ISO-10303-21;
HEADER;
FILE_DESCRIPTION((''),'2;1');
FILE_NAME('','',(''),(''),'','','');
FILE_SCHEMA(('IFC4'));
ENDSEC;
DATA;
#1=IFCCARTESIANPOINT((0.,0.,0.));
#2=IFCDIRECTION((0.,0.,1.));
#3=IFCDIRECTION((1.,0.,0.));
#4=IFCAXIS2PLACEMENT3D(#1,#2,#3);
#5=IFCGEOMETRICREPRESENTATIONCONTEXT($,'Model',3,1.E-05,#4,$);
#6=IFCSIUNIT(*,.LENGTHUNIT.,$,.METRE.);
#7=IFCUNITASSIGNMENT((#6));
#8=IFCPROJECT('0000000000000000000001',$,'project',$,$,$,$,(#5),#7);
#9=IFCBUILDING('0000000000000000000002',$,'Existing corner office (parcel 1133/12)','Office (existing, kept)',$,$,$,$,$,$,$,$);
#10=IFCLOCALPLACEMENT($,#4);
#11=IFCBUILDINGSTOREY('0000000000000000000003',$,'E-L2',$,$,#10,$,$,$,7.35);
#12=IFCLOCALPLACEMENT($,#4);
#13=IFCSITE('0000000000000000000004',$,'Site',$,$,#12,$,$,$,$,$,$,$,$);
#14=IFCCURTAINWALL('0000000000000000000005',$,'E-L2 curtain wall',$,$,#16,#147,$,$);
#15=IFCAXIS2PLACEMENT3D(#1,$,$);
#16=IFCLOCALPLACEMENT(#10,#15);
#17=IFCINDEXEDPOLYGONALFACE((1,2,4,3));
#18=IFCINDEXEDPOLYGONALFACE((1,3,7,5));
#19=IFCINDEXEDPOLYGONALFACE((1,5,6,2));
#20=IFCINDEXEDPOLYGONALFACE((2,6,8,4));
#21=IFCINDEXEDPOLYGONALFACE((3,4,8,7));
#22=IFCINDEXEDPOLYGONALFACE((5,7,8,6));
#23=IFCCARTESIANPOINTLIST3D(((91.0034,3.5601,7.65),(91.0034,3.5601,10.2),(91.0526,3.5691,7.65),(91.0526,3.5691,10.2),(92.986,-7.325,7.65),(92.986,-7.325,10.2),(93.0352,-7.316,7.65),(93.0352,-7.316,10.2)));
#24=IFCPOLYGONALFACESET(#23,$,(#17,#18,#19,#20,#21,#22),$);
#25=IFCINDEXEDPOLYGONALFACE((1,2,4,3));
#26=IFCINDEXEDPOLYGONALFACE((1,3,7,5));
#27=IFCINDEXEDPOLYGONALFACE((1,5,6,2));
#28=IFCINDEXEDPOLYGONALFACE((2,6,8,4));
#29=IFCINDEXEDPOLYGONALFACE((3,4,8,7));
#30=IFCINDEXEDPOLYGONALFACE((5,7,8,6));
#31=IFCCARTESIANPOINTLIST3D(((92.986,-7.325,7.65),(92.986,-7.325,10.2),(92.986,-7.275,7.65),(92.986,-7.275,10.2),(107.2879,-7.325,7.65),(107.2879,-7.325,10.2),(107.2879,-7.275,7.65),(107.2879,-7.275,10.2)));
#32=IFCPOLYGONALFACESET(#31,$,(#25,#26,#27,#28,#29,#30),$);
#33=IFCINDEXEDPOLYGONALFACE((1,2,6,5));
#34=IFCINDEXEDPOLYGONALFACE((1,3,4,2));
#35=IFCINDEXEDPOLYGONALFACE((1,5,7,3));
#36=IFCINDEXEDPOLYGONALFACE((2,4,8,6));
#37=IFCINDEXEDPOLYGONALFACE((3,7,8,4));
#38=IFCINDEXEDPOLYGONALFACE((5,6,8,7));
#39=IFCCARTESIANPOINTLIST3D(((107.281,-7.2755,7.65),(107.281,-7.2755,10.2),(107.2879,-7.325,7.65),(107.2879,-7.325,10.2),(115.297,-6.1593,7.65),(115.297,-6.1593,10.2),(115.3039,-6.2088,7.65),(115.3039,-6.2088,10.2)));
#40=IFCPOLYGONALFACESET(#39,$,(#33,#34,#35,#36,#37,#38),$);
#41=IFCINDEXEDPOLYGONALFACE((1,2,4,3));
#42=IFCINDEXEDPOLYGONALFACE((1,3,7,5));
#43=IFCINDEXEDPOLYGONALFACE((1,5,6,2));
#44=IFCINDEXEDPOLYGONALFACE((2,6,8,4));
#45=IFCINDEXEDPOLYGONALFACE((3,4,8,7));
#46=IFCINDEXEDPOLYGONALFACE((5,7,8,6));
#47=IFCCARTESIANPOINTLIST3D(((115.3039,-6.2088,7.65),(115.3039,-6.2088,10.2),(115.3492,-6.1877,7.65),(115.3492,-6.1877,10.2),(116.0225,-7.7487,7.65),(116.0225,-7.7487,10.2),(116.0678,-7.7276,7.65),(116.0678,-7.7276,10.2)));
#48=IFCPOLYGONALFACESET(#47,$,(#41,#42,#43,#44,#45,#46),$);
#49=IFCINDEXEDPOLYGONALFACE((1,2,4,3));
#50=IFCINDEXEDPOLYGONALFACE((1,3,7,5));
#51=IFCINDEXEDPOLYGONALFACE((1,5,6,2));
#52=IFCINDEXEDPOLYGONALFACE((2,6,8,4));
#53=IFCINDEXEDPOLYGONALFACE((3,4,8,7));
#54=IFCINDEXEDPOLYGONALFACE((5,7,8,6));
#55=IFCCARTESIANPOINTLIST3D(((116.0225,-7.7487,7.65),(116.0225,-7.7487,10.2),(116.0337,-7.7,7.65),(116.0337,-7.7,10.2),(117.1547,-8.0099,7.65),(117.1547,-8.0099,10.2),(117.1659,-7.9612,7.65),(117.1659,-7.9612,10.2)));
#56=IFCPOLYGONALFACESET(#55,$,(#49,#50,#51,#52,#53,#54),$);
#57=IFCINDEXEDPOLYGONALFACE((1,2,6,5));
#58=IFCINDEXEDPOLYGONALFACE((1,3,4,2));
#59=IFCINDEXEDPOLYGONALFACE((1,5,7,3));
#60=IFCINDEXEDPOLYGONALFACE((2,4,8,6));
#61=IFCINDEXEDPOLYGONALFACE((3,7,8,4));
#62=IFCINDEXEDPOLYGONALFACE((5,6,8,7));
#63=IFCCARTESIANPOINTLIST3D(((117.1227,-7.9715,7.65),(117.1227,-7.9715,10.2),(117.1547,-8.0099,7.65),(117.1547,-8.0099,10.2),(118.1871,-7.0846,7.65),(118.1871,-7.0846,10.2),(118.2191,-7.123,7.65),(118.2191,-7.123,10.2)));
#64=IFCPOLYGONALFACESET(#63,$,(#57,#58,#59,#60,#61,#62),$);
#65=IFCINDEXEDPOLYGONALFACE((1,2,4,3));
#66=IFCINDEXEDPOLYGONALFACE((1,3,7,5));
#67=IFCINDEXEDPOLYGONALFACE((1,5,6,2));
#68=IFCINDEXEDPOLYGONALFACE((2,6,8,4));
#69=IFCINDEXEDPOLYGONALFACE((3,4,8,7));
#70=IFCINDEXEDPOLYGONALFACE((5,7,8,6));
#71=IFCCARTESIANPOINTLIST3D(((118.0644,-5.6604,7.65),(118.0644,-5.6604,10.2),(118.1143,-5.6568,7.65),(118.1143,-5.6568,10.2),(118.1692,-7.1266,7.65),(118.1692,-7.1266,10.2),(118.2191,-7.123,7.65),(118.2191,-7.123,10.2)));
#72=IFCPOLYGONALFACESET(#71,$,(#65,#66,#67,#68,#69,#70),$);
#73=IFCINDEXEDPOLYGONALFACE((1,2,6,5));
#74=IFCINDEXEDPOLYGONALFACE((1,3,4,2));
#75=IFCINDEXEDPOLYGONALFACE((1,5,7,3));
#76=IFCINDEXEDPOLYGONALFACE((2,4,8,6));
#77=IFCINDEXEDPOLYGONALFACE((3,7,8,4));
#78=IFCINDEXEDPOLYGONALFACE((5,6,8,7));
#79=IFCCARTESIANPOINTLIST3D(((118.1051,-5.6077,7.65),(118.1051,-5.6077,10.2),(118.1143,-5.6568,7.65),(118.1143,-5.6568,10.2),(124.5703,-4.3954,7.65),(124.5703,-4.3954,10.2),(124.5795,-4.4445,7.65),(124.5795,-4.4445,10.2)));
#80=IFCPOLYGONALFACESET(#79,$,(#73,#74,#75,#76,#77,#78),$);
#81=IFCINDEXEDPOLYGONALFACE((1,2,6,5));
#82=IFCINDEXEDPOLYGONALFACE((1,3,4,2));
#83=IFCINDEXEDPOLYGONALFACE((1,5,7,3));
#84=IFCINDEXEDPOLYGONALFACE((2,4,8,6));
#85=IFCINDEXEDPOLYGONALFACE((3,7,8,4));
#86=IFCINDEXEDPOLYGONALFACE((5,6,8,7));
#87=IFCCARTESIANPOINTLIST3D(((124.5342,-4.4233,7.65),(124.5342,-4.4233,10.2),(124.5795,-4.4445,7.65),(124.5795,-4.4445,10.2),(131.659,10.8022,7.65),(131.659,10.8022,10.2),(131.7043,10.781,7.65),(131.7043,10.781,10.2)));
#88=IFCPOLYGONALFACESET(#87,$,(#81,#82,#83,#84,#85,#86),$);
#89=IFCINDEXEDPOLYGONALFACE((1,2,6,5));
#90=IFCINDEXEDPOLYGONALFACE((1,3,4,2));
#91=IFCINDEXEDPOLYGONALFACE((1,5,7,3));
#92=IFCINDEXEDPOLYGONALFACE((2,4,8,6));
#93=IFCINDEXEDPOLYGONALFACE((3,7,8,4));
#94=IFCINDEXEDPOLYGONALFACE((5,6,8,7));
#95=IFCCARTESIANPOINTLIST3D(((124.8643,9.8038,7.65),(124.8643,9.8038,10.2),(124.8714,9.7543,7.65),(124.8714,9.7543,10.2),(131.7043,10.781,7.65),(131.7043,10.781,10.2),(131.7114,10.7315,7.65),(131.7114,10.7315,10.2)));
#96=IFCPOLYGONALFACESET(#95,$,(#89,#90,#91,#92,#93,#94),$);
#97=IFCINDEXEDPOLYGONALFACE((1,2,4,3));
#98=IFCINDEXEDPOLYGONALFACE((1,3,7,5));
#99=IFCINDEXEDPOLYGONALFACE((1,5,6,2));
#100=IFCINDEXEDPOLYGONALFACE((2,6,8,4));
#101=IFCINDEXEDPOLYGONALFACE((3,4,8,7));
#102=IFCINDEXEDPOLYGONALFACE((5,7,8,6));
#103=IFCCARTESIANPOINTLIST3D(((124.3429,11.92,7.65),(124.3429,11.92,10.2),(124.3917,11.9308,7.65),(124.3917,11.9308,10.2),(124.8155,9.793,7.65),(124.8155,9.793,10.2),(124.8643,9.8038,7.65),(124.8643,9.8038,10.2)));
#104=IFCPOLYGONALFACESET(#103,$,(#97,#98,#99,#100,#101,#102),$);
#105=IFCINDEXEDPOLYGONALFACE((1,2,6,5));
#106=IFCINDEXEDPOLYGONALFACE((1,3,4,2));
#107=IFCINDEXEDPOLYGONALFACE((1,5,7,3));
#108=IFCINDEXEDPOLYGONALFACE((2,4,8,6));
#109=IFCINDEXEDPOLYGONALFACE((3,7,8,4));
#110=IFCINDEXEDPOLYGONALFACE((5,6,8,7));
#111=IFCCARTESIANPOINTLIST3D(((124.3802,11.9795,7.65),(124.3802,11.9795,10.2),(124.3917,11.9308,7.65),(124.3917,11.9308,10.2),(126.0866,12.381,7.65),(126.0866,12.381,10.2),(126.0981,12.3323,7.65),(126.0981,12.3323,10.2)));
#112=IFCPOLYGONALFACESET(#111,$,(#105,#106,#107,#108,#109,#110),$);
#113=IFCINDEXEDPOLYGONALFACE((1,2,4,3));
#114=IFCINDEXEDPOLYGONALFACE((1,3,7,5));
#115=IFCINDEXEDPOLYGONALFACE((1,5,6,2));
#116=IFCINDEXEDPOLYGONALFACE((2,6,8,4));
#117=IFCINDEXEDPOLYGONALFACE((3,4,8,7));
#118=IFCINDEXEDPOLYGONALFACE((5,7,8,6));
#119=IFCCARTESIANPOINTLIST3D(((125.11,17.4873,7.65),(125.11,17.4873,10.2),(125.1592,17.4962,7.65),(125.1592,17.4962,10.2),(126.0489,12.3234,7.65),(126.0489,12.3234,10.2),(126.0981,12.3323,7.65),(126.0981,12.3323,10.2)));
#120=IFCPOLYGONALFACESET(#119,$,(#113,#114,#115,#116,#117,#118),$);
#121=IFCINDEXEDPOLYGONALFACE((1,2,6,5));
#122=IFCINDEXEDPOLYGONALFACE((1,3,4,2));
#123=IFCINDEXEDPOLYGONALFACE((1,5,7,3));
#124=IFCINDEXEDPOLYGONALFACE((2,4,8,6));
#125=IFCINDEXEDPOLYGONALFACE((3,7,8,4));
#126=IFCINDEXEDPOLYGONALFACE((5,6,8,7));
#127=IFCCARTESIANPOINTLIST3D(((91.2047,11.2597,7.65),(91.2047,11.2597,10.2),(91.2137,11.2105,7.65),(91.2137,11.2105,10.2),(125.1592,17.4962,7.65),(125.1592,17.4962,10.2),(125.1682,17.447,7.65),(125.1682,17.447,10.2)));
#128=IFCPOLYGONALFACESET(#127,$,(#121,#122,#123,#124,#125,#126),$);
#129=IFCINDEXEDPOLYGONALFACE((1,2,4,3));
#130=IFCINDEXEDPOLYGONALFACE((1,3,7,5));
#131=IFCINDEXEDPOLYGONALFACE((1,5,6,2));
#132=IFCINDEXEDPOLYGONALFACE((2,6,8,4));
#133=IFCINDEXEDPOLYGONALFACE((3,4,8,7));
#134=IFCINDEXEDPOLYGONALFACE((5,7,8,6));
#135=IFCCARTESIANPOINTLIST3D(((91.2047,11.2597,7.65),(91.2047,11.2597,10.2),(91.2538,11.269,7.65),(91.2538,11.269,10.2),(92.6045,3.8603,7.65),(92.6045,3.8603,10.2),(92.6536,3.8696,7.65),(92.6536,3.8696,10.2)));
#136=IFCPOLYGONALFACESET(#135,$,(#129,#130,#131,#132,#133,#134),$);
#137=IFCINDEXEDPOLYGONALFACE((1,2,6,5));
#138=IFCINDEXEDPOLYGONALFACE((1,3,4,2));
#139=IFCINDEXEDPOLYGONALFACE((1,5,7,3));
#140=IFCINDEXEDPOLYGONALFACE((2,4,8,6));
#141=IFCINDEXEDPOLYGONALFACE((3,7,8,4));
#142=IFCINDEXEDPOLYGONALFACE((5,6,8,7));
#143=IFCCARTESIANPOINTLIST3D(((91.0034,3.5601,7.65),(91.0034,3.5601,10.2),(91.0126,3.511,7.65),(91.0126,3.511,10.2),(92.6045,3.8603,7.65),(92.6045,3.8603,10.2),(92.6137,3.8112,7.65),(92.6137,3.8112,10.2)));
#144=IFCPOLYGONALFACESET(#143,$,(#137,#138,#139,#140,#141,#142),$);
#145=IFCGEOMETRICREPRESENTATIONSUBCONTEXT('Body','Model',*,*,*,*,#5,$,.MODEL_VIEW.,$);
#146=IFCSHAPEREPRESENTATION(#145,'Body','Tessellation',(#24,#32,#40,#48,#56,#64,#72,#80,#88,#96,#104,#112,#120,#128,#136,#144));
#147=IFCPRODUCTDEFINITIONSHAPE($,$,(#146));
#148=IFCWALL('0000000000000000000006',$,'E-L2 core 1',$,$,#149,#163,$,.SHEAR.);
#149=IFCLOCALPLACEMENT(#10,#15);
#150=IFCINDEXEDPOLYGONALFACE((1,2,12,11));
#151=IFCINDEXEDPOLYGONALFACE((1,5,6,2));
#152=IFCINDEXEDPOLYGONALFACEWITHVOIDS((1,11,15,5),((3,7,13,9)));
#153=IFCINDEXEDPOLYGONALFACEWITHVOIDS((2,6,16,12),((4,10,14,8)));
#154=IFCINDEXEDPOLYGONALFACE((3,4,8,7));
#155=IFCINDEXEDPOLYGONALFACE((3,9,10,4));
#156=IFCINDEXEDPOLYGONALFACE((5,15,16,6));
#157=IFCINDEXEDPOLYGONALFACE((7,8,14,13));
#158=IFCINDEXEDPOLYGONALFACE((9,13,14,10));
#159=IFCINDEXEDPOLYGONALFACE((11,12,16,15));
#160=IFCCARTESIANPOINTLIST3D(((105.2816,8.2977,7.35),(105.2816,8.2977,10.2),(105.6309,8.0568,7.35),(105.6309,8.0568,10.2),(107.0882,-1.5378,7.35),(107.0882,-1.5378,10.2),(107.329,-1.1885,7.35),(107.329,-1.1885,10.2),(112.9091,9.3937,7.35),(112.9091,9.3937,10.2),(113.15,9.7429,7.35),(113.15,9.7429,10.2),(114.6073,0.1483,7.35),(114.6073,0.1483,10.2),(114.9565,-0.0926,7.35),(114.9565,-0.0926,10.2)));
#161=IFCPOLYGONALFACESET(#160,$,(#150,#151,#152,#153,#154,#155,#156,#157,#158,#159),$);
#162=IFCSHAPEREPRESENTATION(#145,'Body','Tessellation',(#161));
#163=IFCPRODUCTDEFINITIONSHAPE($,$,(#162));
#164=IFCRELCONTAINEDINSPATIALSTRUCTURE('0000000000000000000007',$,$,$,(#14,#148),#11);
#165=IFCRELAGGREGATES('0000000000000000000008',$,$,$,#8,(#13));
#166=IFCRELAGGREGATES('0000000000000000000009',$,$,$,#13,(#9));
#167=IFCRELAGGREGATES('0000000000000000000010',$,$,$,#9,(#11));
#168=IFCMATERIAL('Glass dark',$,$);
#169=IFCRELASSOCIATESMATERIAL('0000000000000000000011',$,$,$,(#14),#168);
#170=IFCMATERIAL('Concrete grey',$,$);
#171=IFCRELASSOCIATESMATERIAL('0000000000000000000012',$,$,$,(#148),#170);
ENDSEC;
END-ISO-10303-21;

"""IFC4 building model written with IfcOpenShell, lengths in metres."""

from ifc_helpers import new_model, si_unit, frame, origin_with_axes, place, context, subcontext, project, spatial, polyline, outline, extrude, material, element, save


model = new_model("IFC4")

# Units and contexts
model_context = context("Model", 3, precision=1e-05, world=origin_with_axes())
body_context = subcontext(model_context, "Body", "Model", "MODEL_VIEW")
ifc_project = project(units=[si_unit("LENGTHUNIT", "METRE")], contexts=[model_context])

# Site, building, storey
site_placement = place(None, origin_with_axes())
site = spatial("IfcSite", under=ifc_project, at=site_placement, Name="Site")
building = spatial("IfcBuilding", under=site, Name="Existing corner office (parcel 1133/12)", Description="Office (existing, kept)")
storey_placement = place(None, origin_with_axes())
storey = spatial("IfcBuildingStorey", under=building, at=storey_placement, Name="E-L2", Elevation=7.35)

# Shared definitions
ifc_material_1 = material(Name="Concrete grey")

# Curtain wall
ifc_material_2 = material(Name="Glass dark")
curtain_wall_placement = place(storey_placement, origin_with_axes())
element("IfcCurtainWall", 1, at=curtain_wall_placement, inside=storey, material=ifc_material_2, Name="E-L2 curtain wall", context=body_context, shape_type="SweptSolid", body=[
    extrude(outline(polyline([(91.0034, 3.5601), (92.986, -7.325), (93.0352, -7.316), (91.0526, 3.5691), (91.0034, 3.5601)])), frame((0.0, 0.0, 7.65), z_axis=(0.0, 0.0, 1.0), x_axis=(1.0, 0.0, 0.0)), (0.0, 0.0, 1.0), 2.55),
    extrude(outline(polyline([(92.986, -7.325), (107.2879, -7.325), (107.2879, -7.275), (92.986, -7.275), (92.986, -7.325)])), frame((0.0, 0.0, 7.65), z_axis=(0.0, 0.0, 1.0), x_axis=(1.0, 0.0, 0.0)), (0.0, 0.0, 1.0), 2.55),
    extrude(outline(polyline([(107.2879, -7.325), (115.3039, -6.2088), (115.297, -6.1593), (107.281, -7.2755), (107.2879, -7.325)])), frame((0.0, 0.0, 7.65), z_axis=(0.0, 0.0, 1.0), x_axis=(1.0, 0.0, 0.0)), (0.0, 0.0, 1.0), 2.55),
    extrude(outline(polyline([(115.3039, -6.2088), (116.0225, -7.7487), (116.0678, -7.7276), (115.3492, -6.1877), (115.3039, -6.2088)])), frame((0.0, 0.0, 7.65), z_axis=(0.0, 0.0, 1.0), x_axis=(1.0, 0.0, 0.0)), (0.0, 0.0, 1.0), 2.55),
    extrude(outline(polyline([(116.0225, -7.7487), (117.1547, -8.0099), (117.1659, -7.9612), (116.0337, -7.7), (116.0225, -7.7487)])), frame((0.0, 0.0, 7.65), z_axis=(0.0, 0.0, 1.0), x_axis=(1.0, 0.0, 0.0)), (0.0, 0.0, 1.0), 2.55),
    extrude(outline(polyline([(117.1547, -8.0099), (118.2191, -7.123), (118.1871, -7.0846), (117.1227, -7.9715), (117.1547, -8.0099)])), frame((0.0, 0.0, 7.65), z_axis=(0.0, 0.0, 1.0), x_axis=(1.0, 0.0, 0.0)), (0.0, 0.0, 1.0), 2.55),
    extrude(outline(polyline([(118.2191, -7.123), (118.1143, -5.6568), (118.0644, -5.6604), (118.1692, -7.1266), (118.2191, -7.123)])), frame((0.0, 0.0, 7.65), z_axis=(0.0, 0.0, 1.0), x_axis=(1.0, 0.0, 0.0)), (0.0, 0.0, 1.0), 2.55),
    extrude(outline(polyline([(118.1143, -5.6568), (124.5795, -4.4445), (124.5703, -4.3954), (118.1051, -5.6077), (118.1143, -5.6568)])), frame((0.0, 0.0, 7.65), z_axis=(0.0, 0.0, 1.0), x_axis=(1.0, 0.0, 0.0)), (0.0, 0.0, 1.0), 2.55),
    extrude(outline(polyline([(124.5795, -4.4445), (131.7043, 10.781), (131.659, 10.8022), (124.5342, -4.4233), (124.5795, -4.4445)])), frame((0.0, 0.0, 7.65), z_axis=(0.0, 0.0, 1.0), x_axis=(1.0, 0.0, 0.0)), (0.0, 0.0, 1.0), 2.55),
    extrude(outline(polyline([(131.7043, 10.781), (124.8643, 9.8038), (124.8714, 9.7543), (131.7114, 10.7315), (131.7043, 10.781)])), frame((0.0, 0.0, 7.65), z_axis=(0.0, 0.0, 1.0), x_axis=(1.0, 0.0, 0.0)), (0.0, 0.0, 1.0), 2.55),
    extrude(outline(polyline([(124.8643, 9.8038), (124.3917, 11.9308), (124.3429, 11.92), (124.8155, 9.793), (124.8643, 9.8038)])), frame((0.0, 0.0, 7.65), z_axis=(0.0, 0.0, 1.0), x_axis=(1.0, 0.0, 0.0)), (0.0, 0.0, 1.0), 2.55),
    extrude(outline(polyline([(124.3917, 11.9308), (126.0981, 12.3323), (126.0866, 12.381), (124.3802, 11.9795), (124.3917, 11.9308)])), frame((0.0, 0.0, 7.65), z_axis=(0.0, 0.0, 1.0), x_axis=(1.0, 0.0, 0.0)), (0.0, 0.0, 1.0), 2.55),
    extrude(outline(polyline([(126.0981, 12.3323), (125.1592, 17.4962), (125.11, 17.4873), (126.0489, 12.3234), (126.0981, 12.3323)])), frame((0.0, 0.0, 7.65), z_axis=(0.0, 0.0, 1.0), x_axis=(1.0, 0.0, 0.0)), (0.0, 0.0, 1.0), 2.55),
    extrude(outline(polyline([(125.1592, 17.4962), (91.2047, 11.2597), (91.2137, 11.2105), (125.1682, 17.447), (125.1592, 17.4962)])), frame((0.0, 0.0, 7.65), z_axis=(0.0, 0.0, 1.0), x_axis=(1.0, 0.0, 0.0)), (0.0, 0.0, 1.0), 2.55),
    extrude(outline(polyline([(91.2047, 11.2597), (92.6045, 3.8603), (92.6536, 3.8696), (91.2538, 11.269), (91.2047, 11.2597)])), frame((0.0, 0.0, 7.65), z_axis=(0.0, 0.0, 1.0), x_axis=(1.0, 0.0, 0.0)), (0.0, 0.0, 1.0), 2.55),
    extrude(outline(polyline([(92.6045, 3.8603), (91.0034, 3.5601), (91.0126, 3.511), (92.6137, 3.8112), (92.6045, 3.8603)])), frame((0.0, 0.0, 7.65), z_axis=(0.0, 0.0, 1.0), x_axis=(1.0, 0.0, 0.0)), (0.0, 0.0, 1.0), 2.55),
])

# Wall
wall_placement = place(storey_placement, origin_with_axes())
element("IfcWall", 2, at=wall_placement, inside=storey, material=ifc_material_1, Name="E-L2 core 1", PredefinedType="SHEAR", context=body_context, shape_type="SweptSolid", body=[
    extrude(outline(polyline([(113.15, 9.7429), (105.2816, 8.2977), (107.0882, -1.5378), (114.9565, -0.0926), (113.15, 9.7429)]), holes=[polyline([(112.9091, 9.3937), (105.6309, 8.0568), (107.329, -1.1885), (114.6073, 0.1483), (112.9091, 9.3937)])]), frame((0.0, 0.0, 7.35), z_axis=(0.0, 0.0, 1.0), x_axis=(1.0, 0.0, 0.0)), (0.0, 0.0, 1.0), 2.85),
])

save(model, "model.ifc")
